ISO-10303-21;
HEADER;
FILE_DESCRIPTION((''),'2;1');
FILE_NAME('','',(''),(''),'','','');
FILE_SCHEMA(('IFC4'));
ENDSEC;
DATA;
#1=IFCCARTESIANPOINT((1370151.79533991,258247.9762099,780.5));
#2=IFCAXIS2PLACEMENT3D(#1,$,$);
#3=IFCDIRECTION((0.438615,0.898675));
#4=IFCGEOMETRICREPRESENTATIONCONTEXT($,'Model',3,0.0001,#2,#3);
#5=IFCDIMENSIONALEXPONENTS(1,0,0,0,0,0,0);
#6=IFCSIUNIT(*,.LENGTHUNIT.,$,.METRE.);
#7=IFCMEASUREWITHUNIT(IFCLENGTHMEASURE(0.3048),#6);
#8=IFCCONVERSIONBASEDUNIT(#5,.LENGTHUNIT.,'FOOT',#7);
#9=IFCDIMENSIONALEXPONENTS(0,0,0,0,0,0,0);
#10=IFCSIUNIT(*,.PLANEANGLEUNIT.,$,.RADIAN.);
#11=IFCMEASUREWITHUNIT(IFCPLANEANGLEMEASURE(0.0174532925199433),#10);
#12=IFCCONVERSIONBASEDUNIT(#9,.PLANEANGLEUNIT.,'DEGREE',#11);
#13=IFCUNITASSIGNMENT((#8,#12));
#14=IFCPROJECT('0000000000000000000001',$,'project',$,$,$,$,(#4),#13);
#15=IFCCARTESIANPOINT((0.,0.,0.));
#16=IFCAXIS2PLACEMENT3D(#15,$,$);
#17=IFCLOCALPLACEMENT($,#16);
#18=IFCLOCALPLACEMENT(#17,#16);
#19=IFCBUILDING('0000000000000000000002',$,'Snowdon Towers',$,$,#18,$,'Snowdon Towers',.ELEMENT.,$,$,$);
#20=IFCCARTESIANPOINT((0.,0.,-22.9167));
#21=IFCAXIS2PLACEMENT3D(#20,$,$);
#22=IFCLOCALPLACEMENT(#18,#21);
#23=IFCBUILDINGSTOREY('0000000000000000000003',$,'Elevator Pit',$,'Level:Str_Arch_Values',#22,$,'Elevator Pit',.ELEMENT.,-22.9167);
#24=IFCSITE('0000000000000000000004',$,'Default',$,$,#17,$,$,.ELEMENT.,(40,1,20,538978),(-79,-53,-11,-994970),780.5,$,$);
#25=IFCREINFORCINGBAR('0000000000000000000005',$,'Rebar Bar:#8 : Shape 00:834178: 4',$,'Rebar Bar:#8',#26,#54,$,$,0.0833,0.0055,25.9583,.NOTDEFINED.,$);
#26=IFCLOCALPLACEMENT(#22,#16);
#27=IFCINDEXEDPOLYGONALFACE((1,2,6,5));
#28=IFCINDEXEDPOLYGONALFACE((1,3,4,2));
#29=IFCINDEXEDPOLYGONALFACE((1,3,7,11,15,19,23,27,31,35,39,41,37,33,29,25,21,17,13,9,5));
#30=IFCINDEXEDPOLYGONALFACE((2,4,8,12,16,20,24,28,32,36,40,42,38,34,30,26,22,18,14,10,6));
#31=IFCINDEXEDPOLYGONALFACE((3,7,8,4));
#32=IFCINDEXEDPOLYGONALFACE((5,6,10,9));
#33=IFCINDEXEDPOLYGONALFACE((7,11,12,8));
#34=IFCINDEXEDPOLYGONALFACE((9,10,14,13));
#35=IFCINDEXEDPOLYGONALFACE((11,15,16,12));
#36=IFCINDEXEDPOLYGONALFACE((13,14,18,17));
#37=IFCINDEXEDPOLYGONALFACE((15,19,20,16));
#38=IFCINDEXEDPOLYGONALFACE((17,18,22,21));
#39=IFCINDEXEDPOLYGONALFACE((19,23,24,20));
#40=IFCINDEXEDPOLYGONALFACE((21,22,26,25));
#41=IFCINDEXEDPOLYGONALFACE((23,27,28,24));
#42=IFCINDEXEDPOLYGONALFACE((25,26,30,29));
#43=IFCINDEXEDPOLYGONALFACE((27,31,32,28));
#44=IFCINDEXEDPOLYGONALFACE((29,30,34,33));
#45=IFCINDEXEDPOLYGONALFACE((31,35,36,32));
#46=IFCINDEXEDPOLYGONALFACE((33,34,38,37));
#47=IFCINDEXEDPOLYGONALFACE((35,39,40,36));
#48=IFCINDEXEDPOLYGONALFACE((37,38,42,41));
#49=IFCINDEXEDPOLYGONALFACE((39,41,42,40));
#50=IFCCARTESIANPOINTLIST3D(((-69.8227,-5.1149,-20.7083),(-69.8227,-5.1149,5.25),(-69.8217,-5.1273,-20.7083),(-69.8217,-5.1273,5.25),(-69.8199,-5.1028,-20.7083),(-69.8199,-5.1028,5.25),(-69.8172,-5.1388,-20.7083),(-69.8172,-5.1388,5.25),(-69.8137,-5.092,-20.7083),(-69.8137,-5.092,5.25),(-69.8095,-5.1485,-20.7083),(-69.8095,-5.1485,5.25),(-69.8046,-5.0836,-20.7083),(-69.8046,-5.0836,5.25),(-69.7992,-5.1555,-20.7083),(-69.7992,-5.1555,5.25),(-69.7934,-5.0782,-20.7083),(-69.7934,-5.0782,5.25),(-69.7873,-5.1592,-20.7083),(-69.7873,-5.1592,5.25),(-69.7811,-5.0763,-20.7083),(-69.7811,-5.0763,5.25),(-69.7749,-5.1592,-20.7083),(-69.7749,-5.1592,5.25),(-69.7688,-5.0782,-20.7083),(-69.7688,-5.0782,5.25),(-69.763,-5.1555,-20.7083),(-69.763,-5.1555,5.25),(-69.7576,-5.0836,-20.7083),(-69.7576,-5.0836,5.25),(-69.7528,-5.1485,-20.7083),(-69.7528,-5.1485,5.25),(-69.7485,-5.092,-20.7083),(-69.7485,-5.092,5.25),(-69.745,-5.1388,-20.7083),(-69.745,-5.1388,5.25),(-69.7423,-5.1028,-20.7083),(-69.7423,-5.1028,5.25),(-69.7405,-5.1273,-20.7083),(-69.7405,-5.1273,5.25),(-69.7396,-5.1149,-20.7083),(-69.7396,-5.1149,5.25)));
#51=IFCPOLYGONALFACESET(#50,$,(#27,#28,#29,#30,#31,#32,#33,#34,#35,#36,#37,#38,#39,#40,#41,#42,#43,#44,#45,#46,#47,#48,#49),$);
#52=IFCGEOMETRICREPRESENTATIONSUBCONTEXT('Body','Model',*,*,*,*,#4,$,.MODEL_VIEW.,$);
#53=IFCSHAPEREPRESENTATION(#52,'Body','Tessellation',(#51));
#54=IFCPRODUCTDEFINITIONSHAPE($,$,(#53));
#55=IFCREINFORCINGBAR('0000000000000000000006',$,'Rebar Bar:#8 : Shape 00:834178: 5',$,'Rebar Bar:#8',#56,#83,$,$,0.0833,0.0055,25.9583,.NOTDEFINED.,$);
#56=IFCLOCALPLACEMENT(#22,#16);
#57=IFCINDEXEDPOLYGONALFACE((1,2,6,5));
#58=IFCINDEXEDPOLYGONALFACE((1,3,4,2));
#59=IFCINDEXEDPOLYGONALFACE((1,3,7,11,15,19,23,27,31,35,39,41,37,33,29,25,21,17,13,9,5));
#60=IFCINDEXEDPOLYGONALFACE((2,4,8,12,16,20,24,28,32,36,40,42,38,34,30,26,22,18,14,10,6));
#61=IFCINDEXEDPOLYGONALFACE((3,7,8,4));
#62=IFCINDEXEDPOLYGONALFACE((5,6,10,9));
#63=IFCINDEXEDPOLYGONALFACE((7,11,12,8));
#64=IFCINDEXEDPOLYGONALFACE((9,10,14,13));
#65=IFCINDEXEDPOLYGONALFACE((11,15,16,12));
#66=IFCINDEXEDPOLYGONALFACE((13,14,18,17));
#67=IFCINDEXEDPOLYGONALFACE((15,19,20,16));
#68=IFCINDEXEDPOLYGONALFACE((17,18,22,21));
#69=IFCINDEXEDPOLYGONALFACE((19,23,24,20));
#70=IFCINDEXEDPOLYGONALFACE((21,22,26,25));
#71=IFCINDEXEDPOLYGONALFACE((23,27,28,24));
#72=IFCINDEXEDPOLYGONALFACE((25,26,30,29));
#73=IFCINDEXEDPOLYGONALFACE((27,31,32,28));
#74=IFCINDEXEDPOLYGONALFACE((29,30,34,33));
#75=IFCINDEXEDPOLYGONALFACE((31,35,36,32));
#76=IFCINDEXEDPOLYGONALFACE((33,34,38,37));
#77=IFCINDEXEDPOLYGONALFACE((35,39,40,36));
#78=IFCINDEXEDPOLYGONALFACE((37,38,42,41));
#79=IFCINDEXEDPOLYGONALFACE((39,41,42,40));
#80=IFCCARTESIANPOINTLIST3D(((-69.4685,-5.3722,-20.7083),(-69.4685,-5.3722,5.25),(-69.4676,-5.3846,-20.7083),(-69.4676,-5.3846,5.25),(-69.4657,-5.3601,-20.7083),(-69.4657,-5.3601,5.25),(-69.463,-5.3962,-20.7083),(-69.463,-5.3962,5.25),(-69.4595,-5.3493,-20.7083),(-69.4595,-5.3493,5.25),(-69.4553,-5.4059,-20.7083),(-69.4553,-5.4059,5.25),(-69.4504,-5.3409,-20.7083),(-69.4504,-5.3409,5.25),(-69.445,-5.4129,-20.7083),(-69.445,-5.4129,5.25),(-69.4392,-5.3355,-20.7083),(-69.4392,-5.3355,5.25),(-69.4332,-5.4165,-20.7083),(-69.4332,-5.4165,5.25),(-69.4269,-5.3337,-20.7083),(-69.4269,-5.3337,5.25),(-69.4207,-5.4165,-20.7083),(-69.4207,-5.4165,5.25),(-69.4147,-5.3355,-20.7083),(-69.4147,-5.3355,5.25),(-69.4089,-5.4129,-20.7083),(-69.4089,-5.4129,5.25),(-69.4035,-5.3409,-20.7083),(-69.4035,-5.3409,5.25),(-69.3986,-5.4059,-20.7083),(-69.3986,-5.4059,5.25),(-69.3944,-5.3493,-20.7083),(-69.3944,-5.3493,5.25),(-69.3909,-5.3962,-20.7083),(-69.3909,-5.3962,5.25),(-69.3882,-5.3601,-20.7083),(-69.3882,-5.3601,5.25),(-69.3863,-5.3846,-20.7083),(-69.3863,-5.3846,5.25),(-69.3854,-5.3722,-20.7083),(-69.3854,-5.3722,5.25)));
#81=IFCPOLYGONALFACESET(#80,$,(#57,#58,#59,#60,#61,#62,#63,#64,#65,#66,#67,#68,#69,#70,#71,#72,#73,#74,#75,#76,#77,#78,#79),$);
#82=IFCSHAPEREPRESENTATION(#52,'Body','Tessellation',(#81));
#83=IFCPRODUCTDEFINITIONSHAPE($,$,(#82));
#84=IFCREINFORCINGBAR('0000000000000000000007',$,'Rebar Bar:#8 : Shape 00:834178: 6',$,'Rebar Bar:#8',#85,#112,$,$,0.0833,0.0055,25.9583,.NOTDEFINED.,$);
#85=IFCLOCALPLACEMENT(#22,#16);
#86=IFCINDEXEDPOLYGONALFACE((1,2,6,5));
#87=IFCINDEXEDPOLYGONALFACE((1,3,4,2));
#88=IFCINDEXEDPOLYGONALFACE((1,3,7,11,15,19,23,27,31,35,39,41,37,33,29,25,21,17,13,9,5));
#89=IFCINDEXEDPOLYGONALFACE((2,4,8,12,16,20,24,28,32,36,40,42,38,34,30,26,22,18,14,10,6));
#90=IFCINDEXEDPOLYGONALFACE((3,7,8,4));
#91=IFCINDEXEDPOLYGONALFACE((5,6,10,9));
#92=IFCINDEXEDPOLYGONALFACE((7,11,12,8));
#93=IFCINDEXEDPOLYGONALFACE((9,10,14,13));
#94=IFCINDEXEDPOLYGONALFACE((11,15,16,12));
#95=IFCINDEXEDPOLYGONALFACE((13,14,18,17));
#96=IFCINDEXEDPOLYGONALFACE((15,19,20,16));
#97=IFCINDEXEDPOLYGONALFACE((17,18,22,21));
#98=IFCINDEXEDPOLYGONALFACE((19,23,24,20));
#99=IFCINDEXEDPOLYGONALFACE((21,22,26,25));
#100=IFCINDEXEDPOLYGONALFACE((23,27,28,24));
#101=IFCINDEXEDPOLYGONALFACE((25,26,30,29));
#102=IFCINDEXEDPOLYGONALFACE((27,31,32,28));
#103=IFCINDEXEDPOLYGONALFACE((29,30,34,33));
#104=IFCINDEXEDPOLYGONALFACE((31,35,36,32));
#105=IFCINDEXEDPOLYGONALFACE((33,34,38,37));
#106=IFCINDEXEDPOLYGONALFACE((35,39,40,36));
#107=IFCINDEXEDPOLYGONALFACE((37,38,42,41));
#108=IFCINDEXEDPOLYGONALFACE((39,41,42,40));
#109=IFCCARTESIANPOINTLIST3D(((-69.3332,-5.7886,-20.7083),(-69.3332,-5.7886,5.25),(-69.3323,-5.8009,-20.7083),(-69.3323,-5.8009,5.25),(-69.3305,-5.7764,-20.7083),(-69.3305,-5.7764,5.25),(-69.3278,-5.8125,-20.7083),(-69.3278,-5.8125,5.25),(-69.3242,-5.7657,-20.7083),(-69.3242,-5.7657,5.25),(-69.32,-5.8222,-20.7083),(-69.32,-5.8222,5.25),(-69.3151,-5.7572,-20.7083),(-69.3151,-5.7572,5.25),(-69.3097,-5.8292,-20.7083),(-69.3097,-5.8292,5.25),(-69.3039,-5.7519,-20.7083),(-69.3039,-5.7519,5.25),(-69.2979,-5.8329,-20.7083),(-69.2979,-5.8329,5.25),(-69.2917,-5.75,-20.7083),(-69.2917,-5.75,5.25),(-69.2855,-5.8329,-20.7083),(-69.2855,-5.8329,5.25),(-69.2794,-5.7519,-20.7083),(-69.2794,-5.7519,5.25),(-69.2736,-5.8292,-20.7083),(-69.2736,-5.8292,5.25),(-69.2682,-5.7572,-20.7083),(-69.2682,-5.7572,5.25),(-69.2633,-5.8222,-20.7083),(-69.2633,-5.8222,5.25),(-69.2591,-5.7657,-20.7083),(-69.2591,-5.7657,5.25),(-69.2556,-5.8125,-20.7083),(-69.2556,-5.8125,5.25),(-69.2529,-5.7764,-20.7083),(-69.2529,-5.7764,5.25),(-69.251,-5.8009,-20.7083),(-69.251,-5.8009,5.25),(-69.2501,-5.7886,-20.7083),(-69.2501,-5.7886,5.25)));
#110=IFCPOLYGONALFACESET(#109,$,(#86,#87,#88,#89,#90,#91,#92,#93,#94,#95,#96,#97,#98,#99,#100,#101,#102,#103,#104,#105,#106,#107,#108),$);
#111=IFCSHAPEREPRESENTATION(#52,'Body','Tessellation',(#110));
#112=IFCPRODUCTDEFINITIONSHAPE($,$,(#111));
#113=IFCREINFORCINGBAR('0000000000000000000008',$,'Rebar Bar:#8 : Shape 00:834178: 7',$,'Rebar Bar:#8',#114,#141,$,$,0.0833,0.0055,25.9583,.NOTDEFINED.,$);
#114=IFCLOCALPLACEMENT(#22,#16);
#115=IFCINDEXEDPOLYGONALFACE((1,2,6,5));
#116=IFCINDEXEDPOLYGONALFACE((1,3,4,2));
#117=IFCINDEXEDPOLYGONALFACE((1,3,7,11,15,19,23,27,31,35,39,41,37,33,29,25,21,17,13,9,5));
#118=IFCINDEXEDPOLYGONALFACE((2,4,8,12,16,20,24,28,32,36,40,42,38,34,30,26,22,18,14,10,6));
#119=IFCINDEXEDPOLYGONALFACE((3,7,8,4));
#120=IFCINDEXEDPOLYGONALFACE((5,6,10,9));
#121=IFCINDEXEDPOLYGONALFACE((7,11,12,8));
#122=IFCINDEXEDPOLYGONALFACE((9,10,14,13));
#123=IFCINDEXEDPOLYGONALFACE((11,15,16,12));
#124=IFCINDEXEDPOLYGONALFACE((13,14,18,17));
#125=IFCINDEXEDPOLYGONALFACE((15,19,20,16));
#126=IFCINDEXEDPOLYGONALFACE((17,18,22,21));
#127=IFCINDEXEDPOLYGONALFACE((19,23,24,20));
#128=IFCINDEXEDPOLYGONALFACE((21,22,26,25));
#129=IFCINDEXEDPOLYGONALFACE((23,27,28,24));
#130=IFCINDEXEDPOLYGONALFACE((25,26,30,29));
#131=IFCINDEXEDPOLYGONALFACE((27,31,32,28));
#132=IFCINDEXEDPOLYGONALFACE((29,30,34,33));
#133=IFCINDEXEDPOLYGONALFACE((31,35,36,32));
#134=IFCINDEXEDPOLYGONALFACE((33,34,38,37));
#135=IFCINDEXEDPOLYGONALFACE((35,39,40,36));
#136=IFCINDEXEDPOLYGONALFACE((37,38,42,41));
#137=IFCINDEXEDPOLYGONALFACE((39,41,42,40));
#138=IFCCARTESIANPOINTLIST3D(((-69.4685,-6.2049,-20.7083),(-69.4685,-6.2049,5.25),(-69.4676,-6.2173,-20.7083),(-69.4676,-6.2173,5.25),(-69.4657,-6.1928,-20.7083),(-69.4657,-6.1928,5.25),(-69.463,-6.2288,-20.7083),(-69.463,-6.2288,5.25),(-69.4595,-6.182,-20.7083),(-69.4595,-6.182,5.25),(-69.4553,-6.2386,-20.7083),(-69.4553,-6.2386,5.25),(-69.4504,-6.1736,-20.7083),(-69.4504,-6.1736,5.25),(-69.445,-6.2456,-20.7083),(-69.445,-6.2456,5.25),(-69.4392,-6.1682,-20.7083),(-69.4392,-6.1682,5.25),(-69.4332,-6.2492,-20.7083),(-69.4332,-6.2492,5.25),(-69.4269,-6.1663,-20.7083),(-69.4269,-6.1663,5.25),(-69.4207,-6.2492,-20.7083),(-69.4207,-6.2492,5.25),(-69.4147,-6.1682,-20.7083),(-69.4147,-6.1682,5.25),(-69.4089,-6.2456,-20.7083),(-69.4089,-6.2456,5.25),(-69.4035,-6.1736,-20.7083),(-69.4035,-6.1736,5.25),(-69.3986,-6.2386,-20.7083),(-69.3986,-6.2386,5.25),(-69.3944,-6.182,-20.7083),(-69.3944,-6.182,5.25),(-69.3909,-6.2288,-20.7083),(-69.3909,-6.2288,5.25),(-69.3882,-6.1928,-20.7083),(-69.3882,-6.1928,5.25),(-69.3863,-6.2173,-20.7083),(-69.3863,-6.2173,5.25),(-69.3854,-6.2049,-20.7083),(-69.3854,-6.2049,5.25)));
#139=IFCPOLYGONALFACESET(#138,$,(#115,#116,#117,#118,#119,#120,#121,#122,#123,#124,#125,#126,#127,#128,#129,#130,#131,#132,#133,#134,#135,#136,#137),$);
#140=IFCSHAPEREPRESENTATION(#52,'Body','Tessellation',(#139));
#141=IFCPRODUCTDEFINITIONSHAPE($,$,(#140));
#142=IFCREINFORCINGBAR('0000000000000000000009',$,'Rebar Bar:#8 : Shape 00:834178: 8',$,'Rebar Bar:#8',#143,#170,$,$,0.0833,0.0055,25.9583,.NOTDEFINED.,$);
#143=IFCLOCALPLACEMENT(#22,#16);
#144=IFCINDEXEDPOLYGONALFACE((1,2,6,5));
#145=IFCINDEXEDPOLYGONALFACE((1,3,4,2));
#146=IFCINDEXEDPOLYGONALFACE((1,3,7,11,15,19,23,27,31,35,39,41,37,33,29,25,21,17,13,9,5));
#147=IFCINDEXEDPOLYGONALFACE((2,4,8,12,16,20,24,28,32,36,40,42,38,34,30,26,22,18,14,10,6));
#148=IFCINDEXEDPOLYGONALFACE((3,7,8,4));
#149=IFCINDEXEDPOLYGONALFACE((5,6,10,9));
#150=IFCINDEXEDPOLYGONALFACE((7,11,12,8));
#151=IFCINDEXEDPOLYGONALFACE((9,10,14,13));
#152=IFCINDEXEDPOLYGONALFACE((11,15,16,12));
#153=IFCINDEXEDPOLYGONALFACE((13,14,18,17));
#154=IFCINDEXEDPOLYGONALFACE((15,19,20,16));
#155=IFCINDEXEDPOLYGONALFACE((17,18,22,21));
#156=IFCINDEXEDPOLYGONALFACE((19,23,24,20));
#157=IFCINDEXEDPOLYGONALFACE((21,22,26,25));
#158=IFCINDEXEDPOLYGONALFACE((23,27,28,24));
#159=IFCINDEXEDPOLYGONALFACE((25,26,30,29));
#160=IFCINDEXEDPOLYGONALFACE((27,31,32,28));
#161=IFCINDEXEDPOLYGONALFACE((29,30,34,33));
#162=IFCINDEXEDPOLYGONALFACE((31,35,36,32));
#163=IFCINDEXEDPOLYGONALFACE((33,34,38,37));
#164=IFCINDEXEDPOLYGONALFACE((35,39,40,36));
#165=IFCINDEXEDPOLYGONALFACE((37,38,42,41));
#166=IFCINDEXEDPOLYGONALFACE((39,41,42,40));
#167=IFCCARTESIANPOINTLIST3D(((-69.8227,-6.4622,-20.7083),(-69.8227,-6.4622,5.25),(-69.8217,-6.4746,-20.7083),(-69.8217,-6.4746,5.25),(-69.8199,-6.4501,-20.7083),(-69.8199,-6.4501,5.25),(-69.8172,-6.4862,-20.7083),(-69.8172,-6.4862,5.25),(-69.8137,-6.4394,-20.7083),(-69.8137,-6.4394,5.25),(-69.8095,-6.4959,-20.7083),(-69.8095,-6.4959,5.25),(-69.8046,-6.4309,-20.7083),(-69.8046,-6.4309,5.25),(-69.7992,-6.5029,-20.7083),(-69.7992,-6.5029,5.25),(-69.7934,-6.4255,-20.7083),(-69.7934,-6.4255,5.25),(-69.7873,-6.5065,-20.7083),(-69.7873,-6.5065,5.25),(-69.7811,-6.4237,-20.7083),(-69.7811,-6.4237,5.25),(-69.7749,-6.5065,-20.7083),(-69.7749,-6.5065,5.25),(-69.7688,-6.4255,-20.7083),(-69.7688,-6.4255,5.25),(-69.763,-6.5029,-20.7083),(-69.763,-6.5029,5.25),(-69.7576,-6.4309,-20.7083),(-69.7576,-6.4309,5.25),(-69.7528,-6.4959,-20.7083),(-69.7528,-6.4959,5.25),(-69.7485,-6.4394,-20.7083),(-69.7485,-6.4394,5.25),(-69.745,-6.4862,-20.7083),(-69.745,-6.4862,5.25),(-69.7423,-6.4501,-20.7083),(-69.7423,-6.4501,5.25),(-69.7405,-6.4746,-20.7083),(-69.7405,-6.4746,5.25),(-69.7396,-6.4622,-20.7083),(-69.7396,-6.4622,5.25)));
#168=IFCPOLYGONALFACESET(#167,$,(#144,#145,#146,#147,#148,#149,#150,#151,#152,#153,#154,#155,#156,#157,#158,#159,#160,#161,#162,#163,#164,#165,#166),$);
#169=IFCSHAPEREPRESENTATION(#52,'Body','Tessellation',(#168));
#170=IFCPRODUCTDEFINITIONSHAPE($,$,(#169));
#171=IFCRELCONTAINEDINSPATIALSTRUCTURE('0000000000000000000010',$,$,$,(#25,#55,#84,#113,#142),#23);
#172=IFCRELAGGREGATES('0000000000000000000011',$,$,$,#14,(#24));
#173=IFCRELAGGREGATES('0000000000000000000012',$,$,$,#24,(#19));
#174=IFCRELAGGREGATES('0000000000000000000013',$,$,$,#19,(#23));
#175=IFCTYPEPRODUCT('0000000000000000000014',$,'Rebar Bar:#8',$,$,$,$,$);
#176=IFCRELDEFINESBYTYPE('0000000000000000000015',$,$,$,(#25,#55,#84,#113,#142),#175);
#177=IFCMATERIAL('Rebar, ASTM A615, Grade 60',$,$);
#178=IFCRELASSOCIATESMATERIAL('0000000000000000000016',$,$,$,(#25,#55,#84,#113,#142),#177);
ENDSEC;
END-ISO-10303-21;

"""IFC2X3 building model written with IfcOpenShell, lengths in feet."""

from ifc_helpers import new_model, entity, si_unit, converted_unit, direction, frame, origin, place, context, subcontext, project, spatial, material, type_object, element, save


model = new_model("IFC2X3")

# Units and contexts
model_context = context("Model", 3, precision=0.0001, world=frame((1370151.79533991, 258247.9762099, 780.5)), true_north=direction((0.438615, 0.898675)))
body_context = subcontext(model_context, "Body", "Model", "MODEL_VIEW")
ifc_project = project(units=[converted_unit("LENGTHUNIT", "FOOT", entity("IfcLengthMeasure", 0.3048), si_unit("LENGTHUNIT", "METRE"), dimensions=[1, 0, 0, 0, 0, 0, 0]), converted_unit("PLANEANGLEUNIT", "DEGREE", entity("IfcPlaneAngleMeasure", 0.0174532925199433), si_unit("PLANEANGLEUNIT", "RADIAN"), dimensions=[0, 0, 0, 0, 0, 0, 0])], contexts=[model_context])

# Site, building, storey
site_placement = place(None, origin())
site = spatial("IfcSite", under=ifc_project, at=site_placement, Name="Default", CompositionType="ELEMENT", RefLatitude=(40, 1, 20, 538978), RefLongitude=(-79, -53, -11, -994970), RefElevation=780.5)
building_placement = place(site_placement, origin())
building = spatial("IfcBuilding", under=site, at=building_placement, Name="Snowdon Towers", LongName="Snowdon Towers", CompositionType="ELEMENT")
storey_placement = place(building_placement, frame((0.0, 0.0, -22.9167)))
storey = spatial("IfcBuildingStorey", under=building, at=storey_placement, Name="Elevator Pit", ObjectType="Level:Str_Arch_Values", LongName="Elevator Pit", CompositionType="ELEMENT", Elevation=-22.9167)

# Reinforcing bars
ifc_material = material(Name="Rebar, ASTM A615, Grade 60")
type_product_1 = type_object("IfcTypeProduct", Name="Rebar Bar:#8")
reinforcing_bar_1_placement = place(storey_placement, origin())
element("IfcReinforcingBar", 1, at=reinforcing_bar_1_placement, inside=storey, type_object=type_product_1, material=ifc_material, Name="Rebar Bar:#8 : Shape 00:834178: 4", ObjectType="Rebar Bar:#8", BarLength=25.9583, BarRole="NOTDEFINED", CrossSectionArea=0.0055, NominalDiameter=0.0833, context=body_context, shape_type="AdvancedSweptSolid", body=[
    entity("IfcSweptDiskSolid", entity("IfcCompositeCurve", [entity("IfcCompositeCurveSegment", "CONTINUOUS", True, entity("IfcPolyline", [entity("IfcCartesianPoint", [-69.7811, -5.118, -20.7083]), entity("IfcCartesianPoint", [-69.7811, -5.118, 5.25])]))], False), 0.0417, None, 0.0, 1.0),
])
reinforcing_bar_2_placement = place(storey_placement, origin())
element("IfcReinforcingBar", 2, at=reinforcing_bar_2_placement, inside=storey, type_object=type_product_1, material=ifc_material, Name="Rebar Bar:#8 : Shape 00:834178: 5", ObjectType="Rebar Bar:#8", BarLength=25.9583, BarRole="NOTDEFINED", CrossSectionArea=0.0055, NominalDiameter=0.0833, context=body_context, shape_type="AdvancedSweptSolid", body=[
    entity("IfcSweptDiskSolid", entity("IfcCompositeCurve", [entity("IfcCompositeCurveSegment", "CONTINUOUS", True, entity("IfcPolyline", [entity("IfcCartesianPoint", [-69.4269, -5.3753, -20.7083]), entity("IfcCartesianPoint", [-69.4269, -5.3753, 5.25])]))], False), 0.0417, None, 0.0, 1.0),
])
reinforcing_bar_3_placement = place(storey_placement, origin())
element("IfcReinforcingBar", 3, at=reinforcing_bar_3_placement, inside=storey, type_object=type_product_1, material=ifc_material, Name="Rebar Bar:#8 : Shape 00:834178: 6", ObjectType="Rebar Bar:#8", BarLength=25.9583, BarRole="NOTDEFINED", CrossSectionArea=0.0055, NominalDiameter=0.0833, context=body_context, shape_type="AdvancedSweptSolid", body=[
    entity("IfcSweptDiskSolid", entity("IfcCompositeCurve", [entity("IfcCompositeCurveSegment", "CONTINUOUS", True, entity("IfcPolyline", [entity("IfcCartesianPoint", [-69.2917, -5.7917, -20.7083]), entity("IfcCartesianPoint", [-69.2917, -5.7917, 5.25])]))], False), 0.0417, None, 0.0, 1.0),
])
reinforcing_bar_4_placement = place(storey_placement, origin())
element("IfcReinforcingBar", 4, at=reinforcing_bar_4_placement, inside=storey, type_object=type_product_1, material=ifc_material, Name="Rebar Bar:#8 : Shape 00:834178: 7", ObjectType="Rebar Bar:#8", BarLength=25.9583, BarRole="NOTDEFINED", CrossSectionArea=0.0055, NominalDiameter=0.0833, context=body_context, shape_type="AdvancedSweptSolid", body=[
    entity("IfcSweptDiskSolid", entity("IfcCompositeCurve", [entity("IfcCompositeCurveSegment", "CONTINUOUS", True, entity("IfcPolyline", [entity("IfcCartesianPoint", [-69.4269, -6.208, -20.7083]), entity("IfcCartesianPoint", [-69.4269, -6.208, 5.25])]))], False), 0.0417, None, 0.0, 1.0),
])
reinforcing_bar_5_placement = place(storey_placement, origin())
element("IfcReinforcingBar", 5, at=reinforcing_bar_5_placement, inside=storey, type_object=type_product_1, material=ifc_material, Name="Rebar Bar:#8 : Shape 00:834178: 8", ObjectType="Rebar Bar:#8", BarLength=25.9583, BarRole="NOTDEFINED", CrossSectionArea=0.0055, NominalDiameter=0.0833, context=body_context, shape_type="AdvancedSweptSolid", body=[
    entity("IfcSweptDiskSolid", entity("IfcCompositeCurve", [entity("IfcCompositeCurveSegment", "CONTINUOUS", True, entity("IfcPolyline", [entity("IfcCartesianPoint", [-69.7811, -6.4653, -20.7083]), entity("IfcCartesianPoint", [-69.7811, -6.4653, 5.25])]))], False), 0.0417, None, 0.0, 1.0),
])

save(model, "model.ifc")
